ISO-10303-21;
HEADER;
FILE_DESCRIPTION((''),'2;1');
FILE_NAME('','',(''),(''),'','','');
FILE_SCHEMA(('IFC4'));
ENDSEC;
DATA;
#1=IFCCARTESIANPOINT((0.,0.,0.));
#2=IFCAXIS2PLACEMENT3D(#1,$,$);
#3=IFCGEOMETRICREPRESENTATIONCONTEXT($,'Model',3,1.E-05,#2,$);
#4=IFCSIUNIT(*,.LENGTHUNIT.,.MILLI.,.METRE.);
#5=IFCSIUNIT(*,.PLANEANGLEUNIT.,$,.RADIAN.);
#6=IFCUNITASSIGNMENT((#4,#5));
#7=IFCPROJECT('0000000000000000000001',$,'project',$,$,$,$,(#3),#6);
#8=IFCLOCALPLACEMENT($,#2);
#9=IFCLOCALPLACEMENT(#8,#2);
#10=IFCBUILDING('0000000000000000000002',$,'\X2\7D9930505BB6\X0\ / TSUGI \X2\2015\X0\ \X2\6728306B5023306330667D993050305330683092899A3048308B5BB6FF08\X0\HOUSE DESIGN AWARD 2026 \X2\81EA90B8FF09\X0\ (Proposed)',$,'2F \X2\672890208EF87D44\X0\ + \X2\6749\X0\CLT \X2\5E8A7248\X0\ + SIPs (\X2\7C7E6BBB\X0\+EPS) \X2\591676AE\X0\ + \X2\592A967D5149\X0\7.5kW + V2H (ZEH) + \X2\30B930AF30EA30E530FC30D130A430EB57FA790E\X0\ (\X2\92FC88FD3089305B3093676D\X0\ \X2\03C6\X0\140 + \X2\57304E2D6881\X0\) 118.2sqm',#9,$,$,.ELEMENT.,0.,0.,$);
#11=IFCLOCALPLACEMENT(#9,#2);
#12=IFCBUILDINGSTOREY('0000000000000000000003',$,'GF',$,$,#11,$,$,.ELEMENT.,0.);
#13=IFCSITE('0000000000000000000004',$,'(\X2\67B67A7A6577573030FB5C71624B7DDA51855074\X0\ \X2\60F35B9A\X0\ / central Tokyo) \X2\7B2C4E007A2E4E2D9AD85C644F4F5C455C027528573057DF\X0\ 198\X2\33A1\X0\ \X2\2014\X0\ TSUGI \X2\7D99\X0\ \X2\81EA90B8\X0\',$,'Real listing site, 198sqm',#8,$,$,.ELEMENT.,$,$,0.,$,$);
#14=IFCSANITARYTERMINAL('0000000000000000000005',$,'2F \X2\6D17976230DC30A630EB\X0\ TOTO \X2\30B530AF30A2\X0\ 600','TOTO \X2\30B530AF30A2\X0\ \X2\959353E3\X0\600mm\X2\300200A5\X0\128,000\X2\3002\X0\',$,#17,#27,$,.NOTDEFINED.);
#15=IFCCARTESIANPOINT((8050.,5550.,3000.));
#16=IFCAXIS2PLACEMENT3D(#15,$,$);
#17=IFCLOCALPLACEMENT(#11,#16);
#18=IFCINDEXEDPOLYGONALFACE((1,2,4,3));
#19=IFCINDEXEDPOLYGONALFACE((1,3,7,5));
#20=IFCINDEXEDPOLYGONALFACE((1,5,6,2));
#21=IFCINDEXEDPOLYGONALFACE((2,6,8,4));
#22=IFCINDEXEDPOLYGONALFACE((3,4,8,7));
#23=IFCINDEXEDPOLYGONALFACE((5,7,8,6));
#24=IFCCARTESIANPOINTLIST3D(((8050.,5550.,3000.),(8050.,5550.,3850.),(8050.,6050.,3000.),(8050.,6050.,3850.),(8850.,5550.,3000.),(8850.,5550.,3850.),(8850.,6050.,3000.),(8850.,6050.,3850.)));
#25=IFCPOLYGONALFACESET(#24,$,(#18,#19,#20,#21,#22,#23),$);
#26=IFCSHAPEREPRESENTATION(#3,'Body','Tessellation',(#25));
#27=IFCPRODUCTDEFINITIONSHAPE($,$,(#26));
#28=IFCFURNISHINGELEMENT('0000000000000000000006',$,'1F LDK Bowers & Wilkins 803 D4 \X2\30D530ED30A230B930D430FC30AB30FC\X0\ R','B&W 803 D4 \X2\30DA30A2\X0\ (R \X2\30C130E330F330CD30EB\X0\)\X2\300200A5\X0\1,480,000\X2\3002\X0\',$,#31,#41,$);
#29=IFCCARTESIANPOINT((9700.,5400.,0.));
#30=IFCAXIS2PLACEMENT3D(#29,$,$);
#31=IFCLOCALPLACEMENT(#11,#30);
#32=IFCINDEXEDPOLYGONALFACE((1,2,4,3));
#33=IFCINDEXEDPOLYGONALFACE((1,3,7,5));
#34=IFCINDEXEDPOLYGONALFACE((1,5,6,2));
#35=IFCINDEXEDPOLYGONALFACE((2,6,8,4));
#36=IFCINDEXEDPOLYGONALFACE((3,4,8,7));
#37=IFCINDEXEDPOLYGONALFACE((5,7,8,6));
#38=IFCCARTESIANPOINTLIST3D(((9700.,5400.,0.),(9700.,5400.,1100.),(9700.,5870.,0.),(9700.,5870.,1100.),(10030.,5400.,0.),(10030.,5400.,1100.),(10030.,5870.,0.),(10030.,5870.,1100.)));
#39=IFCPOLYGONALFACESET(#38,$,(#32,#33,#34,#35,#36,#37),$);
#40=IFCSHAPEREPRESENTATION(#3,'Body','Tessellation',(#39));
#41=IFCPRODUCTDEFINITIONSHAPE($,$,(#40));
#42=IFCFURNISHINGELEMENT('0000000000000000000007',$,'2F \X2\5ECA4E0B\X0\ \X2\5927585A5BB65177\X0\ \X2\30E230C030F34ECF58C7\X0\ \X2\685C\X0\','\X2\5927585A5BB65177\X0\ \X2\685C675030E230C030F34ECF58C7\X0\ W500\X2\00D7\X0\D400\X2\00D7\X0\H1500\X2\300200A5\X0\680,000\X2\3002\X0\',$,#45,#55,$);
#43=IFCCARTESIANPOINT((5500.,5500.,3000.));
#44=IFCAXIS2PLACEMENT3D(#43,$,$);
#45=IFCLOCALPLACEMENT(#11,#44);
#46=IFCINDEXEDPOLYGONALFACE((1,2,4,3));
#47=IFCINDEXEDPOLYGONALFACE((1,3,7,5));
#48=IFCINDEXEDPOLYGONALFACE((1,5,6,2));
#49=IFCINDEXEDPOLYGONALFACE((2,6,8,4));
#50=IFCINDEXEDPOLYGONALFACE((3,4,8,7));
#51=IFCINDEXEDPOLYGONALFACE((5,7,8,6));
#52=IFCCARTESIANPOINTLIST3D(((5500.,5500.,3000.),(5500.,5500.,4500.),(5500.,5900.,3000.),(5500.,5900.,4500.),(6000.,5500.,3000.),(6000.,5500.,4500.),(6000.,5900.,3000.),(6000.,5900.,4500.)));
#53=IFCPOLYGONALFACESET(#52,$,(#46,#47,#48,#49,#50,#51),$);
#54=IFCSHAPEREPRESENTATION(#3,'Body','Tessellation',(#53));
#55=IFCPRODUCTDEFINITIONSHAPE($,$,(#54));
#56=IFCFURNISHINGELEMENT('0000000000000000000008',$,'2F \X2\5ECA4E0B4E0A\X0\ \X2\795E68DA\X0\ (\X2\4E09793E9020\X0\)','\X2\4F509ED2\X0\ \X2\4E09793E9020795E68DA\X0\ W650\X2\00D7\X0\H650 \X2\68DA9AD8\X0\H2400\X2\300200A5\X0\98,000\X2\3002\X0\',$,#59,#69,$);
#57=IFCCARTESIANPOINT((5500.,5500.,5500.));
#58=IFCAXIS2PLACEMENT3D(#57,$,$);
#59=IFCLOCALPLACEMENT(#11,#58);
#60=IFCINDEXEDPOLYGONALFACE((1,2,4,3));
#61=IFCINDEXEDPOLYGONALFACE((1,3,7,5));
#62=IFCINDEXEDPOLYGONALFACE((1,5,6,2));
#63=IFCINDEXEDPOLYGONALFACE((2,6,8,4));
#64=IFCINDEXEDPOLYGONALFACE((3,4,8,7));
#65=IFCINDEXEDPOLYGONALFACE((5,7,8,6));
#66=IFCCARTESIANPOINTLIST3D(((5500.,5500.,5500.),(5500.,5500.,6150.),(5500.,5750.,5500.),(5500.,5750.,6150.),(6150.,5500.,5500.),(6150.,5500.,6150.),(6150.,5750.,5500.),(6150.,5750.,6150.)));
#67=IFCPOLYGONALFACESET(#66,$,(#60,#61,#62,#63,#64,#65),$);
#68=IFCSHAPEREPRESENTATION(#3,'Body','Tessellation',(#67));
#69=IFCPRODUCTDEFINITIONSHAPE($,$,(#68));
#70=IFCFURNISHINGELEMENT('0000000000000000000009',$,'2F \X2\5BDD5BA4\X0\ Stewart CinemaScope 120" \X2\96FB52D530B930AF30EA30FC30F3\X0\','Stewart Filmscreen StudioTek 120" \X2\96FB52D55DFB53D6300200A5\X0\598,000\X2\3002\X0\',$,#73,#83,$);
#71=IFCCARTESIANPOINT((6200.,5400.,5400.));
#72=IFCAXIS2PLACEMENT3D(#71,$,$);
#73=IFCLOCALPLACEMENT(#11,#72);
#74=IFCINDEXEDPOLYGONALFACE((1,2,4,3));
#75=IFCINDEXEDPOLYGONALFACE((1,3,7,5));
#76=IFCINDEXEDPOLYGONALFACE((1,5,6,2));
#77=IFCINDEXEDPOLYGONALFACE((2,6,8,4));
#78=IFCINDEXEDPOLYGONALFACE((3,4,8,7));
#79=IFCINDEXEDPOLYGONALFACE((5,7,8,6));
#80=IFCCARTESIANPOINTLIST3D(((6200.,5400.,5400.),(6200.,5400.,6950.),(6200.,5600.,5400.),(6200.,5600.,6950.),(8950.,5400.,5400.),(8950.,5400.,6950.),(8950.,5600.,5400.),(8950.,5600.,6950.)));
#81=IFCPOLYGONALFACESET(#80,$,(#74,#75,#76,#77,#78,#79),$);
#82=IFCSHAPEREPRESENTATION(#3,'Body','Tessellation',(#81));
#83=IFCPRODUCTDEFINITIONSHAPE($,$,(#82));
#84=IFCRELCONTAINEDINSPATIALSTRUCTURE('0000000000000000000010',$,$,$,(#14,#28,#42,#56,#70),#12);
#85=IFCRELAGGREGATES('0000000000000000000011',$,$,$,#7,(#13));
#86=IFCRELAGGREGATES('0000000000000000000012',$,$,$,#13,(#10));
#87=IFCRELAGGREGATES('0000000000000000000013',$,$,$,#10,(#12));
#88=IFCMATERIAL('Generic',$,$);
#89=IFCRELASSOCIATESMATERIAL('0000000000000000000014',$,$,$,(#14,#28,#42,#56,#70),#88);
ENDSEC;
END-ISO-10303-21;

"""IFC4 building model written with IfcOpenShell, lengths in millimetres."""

from ifc_helpers import new_model, si_unit, frame, frame_2d, origin, place, context, project, spatial, rectangle, extrude, material, element, save


model = new_model("IFC4")

# Units and contexts
model_context = context("Model", 3, precision=1e-05, world=origin())
ifc_project = project(units=[si_unit("LENGTHUNIT", "METRE", prefix="MILLI"), si_unit("PLANEANGLEUNIT", "RADIAN")], contexts=[model_context])

# Site, building, storey
site_placement = place(None, origin())
site = spatial("IfcSite", under=ifc_project, at=site_placement, Name="(架空敷地・山手線内側 想定 / central Tokyo) 第一種中高層住居専用地域 198㎡ — TSUGI 継 自邸", ObjectType="Real listing site, 198sqm", CompositionType="ELEMENT", RefElevation=0.0)
building_placement = place(site_placement, origin())
building = spatial("IfcBuilding", under=site, at=building_placement, Name="継ぐ家 / TSUGI ― 木に倣って継ぐことを覚える家（HOUSE DESIGN AWARD 2026 自邸） (Proposed)", ObjectType="2F 木造軸組 + 杉CLT 床版 + SIPs (籾殻+EPS) 外皮 + 太陽光7.5kW + V2H (ZEH) + スクリューパイル基礎 (鋼製らせん杭 φ140 + 地中梁) 118.2sqm", CompositionType="ELEMENT", ElevationOfRefHeight=0.0, ElevationOfTerrain=0.0)
storey_placement = place(building_placement, origin())
storey = spatial("IfcBuildingStorey", under=building, at=storey_placement, Name="GF", CompositionType="ELEMENT", Elevation=0.0)

# Shared definitions
ifc_material_1 = material(Name="Generic")

# Sanitary terminal
sanitary_terminal_1_placement = place(storey_placement, frame((8050.0, 5550.0, 3000.0)))
element("IfcSanitaryTerminal", 1, at=sanitary_terminal_1_placement, inside=storey, material=ifc_material_1, Name="2F 洗面ボウル TOTO サクア 600", Description="TOTO サクア 間口600mm。¥128,000。", PredefinedType="NOTDEFINED", context=model_context, shape_type="SweptSolid", body=[
    extrude(rectangle(XDim=800.0, YDim=500.0, at=frame_2d((400.0, 250.0))), frame((8050.0, 5550.0, 3000.0)), (0.0, 0.0, 1.0), 850.0),
])

# Furnishing elements
furnishing_1_placement = place(storey_placement, frame((9700.0, 5400.0, 0.0)))
element("IfcFurnishingElement", 2, at=furnishing_1_placement, inside=storey, material=ifc_material_1, Name="1F LDK Bowers & Wilkins 803 D4 フロアスピーカー R", Description="B&W 803 D4 ペア (R チャンネル)。¥1,480,000。", context=model_context, shape_type="SweptSolid", body=[
    extrude(rectangle(XDim=330.0, YDim=470.0, at=frame_2d((165.0, 235.0))), frame((9700.0, 5400.0, 0.0)), (0.0, 0.0, 1.0), 1100.0),
])
furnishing_2_placement = place(storey_placement, frame((5500.0, 5500.0, 3000.0)))
element("IfcFurnishingElement", 3, at=furnishing_2_placement, inside=storey, material=ifc_material_1, Name="2F 廊下 大塚家具 モダン仏壇 桜", Description="大塚家具 桜材モダン仏壇 W500×D400×H1500。¥680,000。", context=model_context, shape_type="SweptSolid", body=[
    extrude(rectangle(XDim=500.0, YDim=400.0, at=frame_2d((250.0, 200.0))), frame((5500.0, 5500.0, 3000.0)), (0.0, 0.0, 1.0), 1500.0),
])
furnishing_3_placement = place(storey_placement, frame((5500.0, 5500.0, 5500.0)))
element("IfcFurnishingElement", 4, at=furnishing_3_placement, inside=storey, material=ifc_material_1, Name="2F 廊下上 神棚 (三社造)", Description="佐黒 三社造神棚 W650×H650 棚高H2400。¥98,000。", context=model_context, shape_type="SweptSolid", body=[
    extrude(rectangle(XDim=650.0, YDim=250.0, at=frame_2d((325.0, 125.0))), frame((5500.0, 5500.0, 5500.0)), (0.0, 0.0, 1.0), 650.0),
])
furnishing_4_placement = place(storey_placement, frame((6200.0, 5400.0, 5400.0)))
element("IfcFurnishingElement", 5, at=furnishing_4_placement, inside=storey, material=ifc_material_1, Name="2F 寝室 Stewart CinemaScope 120\" 電動スクリーン", Description="Stewart Filmscreen StudioTek 120\" 電動巻取。¥598,000。", context=model_context, shape_type="SweptSolid", body=[
    extrude(rectangle(XDim=2750.0, YDim=200.0, at=frame_2d((1375.0, 100.0))), frame((6200.0, 5400.0, 5400.0)), (0.0, 0.0, 1.0), 1550.0),
])

save(model, "model.ifc")
